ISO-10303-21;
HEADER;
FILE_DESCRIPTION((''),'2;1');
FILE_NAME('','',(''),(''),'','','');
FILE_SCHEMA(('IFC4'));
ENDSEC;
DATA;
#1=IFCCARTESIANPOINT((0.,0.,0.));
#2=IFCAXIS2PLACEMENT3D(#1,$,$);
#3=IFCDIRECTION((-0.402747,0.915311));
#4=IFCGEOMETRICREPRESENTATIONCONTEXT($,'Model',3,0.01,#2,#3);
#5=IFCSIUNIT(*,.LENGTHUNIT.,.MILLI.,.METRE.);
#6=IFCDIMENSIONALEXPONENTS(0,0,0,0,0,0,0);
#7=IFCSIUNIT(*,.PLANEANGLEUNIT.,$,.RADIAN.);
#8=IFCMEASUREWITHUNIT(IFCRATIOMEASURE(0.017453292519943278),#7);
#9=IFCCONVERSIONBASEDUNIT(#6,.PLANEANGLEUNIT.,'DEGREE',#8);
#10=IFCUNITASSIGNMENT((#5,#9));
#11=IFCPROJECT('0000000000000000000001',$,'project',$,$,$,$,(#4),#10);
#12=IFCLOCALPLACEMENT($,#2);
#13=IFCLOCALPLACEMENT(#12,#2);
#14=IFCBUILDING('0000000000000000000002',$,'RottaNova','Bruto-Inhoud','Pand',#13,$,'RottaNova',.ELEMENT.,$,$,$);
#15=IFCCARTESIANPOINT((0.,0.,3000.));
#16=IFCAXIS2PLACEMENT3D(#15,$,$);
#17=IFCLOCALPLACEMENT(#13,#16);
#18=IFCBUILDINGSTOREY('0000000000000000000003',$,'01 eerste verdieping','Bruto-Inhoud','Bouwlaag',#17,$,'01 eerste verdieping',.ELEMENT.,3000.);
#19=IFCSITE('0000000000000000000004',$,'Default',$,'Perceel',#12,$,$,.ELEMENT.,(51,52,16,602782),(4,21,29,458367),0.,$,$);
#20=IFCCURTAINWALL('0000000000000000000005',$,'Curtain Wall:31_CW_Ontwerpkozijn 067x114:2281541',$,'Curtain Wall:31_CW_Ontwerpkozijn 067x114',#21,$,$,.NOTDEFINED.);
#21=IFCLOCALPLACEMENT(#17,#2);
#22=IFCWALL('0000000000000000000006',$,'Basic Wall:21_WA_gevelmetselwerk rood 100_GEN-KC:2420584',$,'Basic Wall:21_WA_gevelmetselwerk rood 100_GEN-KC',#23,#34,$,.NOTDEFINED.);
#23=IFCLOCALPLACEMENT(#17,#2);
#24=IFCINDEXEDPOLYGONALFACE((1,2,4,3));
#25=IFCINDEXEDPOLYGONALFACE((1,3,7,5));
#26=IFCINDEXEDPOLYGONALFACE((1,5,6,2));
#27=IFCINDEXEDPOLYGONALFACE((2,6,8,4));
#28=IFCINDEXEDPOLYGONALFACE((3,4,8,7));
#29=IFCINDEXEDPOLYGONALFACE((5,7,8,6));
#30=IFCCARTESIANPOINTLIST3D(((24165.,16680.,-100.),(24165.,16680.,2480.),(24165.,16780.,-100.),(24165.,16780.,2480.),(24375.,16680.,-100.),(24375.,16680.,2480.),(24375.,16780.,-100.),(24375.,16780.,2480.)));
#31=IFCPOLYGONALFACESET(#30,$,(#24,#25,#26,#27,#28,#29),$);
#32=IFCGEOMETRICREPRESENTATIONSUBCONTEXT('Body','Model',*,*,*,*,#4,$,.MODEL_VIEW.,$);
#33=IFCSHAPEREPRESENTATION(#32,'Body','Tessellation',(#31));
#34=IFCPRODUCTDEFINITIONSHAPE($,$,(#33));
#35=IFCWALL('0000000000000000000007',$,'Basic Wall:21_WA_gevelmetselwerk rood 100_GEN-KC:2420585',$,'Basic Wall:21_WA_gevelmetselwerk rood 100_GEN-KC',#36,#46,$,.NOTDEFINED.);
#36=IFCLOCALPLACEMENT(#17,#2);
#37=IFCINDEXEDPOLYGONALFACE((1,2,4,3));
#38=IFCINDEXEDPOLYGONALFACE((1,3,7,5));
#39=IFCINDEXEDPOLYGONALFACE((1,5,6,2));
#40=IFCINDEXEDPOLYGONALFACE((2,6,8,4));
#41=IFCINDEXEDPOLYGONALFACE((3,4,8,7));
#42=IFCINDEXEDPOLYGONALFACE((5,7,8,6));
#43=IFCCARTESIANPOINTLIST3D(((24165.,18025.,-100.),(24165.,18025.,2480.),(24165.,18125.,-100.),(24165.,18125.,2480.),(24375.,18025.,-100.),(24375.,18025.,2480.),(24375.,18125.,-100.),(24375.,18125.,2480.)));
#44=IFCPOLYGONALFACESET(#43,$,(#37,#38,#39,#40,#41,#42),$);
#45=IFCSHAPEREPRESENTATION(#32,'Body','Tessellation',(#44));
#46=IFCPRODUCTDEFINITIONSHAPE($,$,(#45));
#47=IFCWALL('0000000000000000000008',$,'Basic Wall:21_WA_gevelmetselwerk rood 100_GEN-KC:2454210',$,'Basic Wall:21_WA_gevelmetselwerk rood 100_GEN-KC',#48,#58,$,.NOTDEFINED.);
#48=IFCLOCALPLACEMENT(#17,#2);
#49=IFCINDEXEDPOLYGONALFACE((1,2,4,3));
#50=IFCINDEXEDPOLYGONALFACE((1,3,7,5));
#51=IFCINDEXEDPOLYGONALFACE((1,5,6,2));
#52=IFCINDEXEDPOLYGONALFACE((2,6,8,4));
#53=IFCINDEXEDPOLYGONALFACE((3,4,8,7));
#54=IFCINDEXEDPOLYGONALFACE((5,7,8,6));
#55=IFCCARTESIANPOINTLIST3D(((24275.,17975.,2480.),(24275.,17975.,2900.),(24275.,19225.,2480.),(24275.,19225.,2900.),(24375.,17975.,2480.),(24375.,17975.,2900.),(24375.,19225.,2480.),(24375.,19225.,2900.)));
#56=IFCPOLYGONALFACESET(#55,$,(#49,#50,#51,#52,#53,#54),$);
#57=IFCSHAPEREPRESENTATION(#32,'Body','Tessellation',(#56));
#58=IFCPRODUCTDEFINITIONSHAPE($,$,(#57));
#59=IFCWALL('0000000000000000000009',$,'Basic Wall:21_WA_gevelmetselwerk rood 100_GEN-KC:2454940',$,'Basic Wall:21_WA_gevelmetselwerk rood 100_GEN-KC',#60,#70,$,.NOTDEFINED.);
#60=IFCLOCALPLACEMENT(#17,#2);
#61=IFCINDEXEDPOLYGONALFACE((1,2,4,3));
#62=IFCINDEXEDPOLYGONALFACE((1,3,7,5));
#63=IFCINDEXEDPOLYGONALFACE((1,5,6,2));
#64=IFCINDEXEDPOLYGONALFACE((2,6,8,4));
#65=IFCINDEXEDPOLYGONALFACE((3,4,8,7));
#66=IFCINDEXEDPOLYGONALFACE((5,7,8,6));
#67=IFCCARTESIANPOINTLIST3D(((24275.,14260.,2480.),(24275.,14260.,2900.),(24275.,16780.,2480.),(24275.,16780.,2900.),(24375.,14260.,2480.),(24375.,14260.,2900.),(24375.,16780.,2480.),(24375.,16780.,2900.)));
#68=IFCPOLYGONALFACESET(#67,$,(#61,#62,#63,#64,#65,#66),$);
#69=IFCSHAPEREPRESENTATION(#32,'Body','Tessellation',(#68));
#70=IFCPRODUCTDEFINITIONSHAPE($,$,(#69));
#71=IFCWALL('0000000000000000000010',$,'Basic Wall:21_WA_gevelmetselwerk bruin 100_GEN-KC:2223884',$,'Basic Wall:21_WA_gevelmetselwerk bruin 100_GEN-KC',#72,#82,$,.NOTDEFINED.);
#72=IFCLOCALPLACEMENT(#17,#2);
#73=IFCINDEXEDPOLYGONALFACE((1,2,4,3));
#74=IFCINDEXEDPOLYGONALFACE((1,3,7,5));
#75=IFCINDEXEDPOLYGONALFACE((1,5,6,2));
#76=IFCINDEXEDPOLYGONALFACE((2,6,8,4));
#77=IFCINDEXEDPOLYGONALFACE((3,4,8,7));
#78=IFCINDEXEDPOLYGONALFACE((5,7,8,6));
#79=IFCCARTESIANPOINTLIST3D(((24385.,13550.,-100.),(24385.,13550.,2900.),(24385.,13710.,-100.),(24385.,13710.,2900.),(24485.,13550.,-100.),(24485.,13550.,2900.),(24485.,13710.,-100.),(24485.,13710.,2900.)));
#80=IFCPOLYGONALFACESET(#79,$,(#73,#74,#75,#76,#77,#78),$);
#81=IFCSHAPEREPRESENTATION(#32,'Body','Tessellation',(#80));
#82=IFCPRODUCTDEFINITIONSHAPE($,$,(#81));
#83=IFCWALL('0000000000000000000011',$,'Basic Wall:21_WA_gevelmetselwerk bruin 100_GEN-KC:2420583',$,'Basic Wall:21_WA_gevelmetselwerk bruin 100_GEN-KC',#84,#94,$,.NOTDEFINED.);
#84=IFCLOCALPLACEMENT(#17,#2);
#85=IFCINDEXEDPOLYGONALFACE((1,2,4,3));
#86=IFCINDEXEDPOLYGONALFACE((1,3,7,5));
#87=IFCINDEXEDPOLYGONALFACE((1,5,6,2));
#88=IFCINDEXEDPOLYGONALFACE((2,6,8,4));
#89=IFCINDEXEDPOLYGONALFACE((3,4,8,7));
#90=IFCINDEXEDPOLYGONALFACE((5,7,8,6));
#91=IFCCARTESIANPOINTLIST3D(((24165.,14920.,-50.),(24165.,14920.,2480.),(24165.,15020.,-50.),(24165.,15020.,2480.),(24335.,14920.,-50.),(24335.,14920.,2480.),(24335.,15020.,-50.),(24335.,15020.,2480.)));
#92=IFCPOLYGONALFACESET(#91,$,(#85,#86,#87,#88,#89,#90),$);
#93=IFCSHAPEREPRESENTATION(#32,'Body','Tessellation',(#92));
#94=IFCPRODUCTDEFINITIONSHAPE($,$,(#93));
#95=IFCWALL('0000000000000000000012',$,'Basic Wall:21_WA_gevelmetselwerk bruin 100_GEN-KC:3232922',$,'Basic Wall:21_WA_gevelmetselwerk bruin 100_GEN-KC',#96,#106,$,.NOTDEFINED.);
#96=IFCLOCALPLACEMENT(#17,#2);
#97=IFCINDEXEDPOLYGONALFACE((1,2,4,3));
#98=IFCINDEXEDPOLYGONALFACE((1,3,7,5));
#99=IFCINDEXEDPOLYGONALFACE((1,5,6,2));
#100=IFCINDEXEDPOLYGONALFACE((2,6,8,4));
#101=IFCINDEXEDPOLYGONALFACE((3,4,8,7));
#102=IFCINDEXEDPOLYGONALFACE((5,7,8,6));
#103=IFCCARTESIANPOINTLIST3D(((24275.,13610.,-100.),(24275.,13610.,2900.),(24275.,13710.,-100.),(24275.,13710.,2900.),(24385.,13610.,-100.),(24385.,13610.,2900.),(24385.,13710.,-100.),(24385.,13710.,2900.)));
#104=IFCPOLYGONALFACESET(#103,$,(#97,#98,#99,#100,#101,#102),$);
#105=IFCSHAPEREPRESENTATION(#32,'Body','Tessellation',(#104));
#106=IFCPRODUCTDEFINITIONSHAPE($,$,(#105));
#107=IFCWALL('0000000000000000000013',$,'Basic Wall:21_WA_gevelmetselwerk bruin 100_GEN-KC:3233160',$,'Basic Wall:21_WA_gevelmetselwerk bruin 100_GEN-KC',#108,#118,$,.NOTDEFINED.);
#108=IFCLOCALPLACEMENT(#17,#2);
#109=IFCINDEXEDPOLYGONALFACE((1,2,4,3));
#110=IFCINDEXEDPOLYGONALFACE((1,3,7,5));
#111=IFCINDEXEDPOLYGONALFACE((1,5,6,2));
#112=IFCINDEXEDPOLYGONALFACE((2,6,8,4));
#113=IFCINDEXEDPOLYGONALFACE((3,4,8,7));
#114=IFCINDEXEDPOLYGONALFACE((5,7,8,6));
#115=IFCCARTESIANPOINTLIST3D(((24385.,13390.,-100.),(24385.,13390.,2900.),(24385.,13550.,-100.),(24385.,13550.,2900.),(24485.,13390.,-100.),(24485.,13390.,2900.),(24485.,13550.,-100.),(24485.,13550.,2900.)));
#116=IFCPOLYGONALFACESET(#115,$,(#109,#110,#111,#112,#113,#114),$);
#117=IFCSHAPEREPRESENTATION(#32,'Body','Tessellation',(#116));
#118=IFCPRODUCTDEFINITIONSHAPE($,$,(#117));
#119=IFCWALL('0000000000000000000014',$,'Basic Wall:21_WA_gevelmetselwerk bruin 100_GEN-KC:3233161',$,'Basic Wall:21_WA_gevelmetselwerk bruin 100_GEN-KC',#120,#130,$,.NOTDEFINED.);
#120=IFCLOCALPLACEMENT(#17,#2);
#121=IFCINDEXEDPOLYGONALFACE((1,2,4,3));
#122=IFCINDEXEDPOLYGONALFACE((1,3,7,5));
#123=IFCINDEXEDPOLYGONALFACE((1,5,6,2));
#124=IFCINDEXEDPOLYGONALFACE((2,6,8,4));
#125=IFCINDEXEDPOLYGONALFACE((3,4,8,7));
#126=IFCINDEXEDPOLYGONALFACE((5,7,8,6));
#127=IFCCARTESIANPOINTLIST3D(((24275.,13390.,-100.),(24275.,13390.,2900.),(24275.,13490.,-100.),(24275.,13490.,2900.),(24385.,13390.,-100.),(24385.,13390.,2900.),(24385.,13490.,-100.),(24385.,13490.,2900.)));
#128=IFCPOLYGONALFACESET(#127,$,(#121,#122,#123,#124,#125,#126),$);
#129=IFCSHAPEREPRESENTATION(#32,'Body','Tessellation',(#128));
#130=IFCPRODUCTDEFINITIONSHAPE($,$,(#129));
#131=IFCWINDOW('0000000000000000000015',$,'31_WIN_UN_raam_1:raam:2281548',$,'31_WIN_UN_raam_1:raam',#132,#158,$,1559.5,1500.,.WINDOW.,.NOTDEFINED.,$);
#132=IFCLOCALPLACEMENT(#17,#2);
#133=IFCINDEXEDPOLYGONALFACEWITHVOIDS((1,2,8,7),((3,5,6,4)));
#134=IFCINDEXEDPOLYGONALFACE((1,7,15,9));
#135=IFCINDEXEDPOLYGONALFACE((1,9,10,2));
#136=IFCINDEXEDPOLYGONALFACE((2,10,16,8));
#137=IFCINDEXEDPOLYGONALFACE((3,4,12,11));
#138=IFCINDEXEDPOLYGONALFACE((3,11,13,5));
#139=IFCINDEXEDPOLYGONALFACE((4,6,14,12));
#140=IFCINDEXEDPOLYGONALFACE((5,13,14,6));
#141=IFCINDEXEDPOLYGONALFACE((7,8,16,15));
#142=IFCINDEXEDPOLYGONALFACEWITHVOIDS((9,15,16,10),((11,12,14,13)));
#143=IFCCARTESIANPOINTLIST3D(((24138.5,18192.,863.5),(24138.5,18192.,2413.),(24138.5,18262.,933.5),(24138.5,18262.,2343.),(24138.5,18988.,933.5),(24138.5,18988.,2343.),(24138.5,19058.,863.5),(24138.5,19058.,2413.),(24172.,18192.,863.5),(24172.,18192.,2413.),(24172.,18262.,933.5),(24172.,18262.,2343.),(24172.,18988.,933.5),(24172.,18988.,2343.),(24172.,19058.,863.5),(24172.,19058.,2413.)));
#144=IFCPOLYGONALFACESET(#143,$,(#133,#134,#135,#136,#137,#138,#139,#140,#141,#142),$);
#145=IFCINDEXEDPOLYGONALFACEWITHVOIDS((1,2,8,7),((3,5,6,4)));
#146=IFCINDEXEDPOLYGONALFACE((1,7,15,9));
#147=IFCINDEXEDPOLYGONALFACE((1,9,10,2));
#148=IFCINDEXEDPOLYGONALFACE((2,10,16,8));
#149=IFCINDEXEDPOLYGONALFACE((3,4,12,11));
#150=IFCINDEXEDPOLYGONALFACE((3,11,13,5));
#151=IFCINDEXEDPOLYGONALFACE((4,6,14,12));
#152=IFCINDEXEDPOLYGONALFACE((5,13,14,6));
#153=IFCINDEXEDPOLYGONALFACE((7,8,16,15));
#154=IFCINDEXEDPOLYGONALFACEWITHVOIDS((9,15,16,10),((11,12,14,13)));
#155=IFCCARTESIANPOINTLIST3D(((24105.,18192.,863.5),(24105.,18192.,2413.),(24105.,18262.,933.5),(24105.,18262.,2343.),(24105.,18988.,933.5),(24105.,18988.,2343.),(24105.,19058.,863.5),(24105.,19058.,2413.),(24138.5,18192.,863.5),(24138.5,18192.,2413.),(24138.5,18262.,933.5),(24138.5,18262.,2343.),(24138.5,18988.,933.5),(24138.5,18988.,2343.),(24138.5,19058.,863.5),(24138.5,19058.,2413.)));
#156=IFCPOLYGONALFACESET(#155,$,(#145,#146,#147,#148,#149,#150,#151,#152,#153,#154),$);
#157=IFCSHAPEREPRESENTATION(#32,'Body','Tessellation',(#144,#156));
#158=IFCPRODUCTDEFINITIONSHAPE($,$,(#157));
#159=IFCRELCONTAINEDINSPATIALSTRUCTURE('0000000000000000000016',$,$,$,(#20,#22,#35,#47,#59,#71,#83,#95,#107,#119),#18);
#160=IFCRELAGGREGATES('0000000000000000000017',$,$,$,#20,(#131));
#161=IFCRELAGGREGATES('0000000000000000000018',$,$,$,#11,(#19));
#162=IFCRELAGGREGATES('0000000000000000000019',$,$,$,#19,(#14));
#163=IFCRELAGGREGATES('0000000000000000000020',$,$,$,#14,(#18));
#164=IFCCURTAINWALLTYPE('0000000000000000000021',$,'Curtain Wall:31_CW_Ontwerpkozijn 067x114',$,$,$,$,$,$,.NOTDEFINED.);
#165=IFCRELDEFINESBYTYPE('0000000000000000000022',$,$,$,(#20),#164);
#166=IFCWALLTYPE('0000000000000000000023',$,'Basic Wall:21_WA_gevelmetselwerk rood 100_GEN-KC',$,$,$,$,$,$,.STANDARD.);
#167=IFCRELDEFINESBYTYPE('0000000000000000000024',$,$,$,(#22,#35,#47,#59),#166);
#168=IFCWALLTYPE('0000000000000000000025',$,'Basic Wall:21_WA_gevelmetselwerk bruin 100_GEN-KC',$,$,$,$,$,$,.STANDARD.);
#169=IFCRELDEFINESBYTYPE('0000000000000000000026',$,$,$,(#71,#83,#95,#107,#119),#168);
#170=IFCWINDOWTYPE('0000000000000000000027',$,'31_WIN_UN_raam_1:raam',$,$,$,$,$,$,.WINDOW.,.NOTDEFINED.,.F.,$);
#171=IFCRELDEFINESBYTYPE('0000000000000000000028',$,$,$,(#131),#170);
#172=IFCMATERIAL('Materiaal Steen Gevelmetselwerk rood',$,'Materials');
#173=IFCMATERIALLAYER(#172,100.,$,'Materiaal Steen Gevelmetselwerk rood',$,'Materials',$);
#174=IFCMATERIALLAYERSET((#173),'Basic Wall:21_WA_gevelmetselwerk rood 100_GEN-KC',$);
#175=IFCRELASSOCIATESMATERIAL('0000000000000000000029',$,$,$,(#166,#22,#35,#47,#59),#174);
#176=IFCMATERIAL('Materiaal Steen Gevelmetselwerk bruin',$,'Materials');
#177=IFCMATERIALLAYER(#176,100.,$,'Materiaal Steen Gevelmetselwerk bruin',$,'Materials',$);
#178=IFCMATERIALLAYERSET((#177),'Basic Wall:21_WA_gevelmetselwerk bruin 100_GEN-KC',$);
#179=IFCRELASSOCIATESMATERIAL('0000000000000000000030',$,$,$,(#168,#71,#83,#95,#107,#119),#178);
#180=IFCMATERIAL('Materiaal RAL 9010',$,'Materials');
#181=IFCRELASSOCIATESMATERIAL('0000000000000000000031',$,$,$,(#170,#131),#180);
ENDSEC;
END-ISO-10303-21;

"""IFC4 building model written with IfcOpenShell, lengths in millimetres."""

from ifc_helpers import new_model, entity, si_unit, converted_unit, direction, frame, frame_2d, origin, place, context, subcontext, project, spatial, polyline, rectangle, outline, extrude, clip, bounded_halfspace, source, transform, mapped, material, layer, layer_set, type_object, type_shapes, element, aggregate, save


model = new_model("IFC4")

# Units and contexts
model_context = context("Model", 3, precision=0.01, world=origin(), true_north=direction((-0.402747, 0.915311)))
body_context = subcontext(model_context, "Body", "Model", "MODEL_VIEW")
ifc_project = project(units=[si_unit("LENGTHUNIT", "METRE", prefix="MILLI"), converted_unit("PLANEANGLEUNIT", "DEGREE", entity("IfcRatioMeasure", 0.017453292519943278), si_unit("PLANEANGLEUNIT", "RADIAN"), dimensions=[0, 0, 0, 0, 0, 0, 0])], contexts=[model_context])

# Site, building, storey
site_placement = place(None, origin())
site = spatial("IfcSite", under=ifc_project, at=site_placement, Name="Default", ObjectType="Perceel", CompositionType="ELEMENT", RefLatitude=(51, 52, 16, 602782), RefLongitude=(4, 21, 29, 458367), RefElevation=0.0)
building_placement = place(site_placement, origin())
building = spatial("IfcBuilding", under=site, at=building_placement, Name="RottaNova", Description="Bruto-Inhoud", ObjectType="Pand", LongName="RottaNova", CompositionType="ELEMENT")
storey_placement = place(building_placement, frame((0.0, 0.0, 3000.0)))
storey = spatial("IfcBuildingStorey", under=building, at=storey_placement, Name="01 eerste verdieping", Description="Bruto-Inhoud", ObjectType="Bouwlaag", LongName="01 eerste verdieping", CompositionType="ELEMENT", Elevation=3000.0)

# Curtain wall
curtain_wall_type = type_object("IfcCurtainWallType", Name="Curtain Wall:31_CW_Ontwerpkozijn 067x114", PredefinedType="NOTDEFINED")
curtain_wall_1_placement = place(storey_placement, frame((0.0, 0.0, -3000.0)))
curtain_wall_1 = element("IfcCurtainWall", 1, at=curtain_wall_1_placement, inside=storey, type_object=curtain_wall_type, Name="Curtain Wall:31_CW_Ontwerpkozijn 067x114:2281541", ObjectType="Curtain Wall:31_CW_Ontwerpkozijn 067x114", PredefinedType="NOTDEFINED")

# Shared definitions
ifc_material_1 = material(Name="Materiaal Steen Gevelmetselwerk rood", Category="Materials")
ifc_layer_1 = layer(ifc_material_1, 100.0, Name="Materiaal Steen Gevelmetselwerk rood", Category="Materials")
ifc_layer_set_1 = layer_set([ifc_layer_1], Name="Basic Wall:21_WA_gevelmetselwerk rood 100_GEN-KC")
wall_type_1 = type_object("IfcWallType", Name="Basic Wall:21_WA_gevelmetselwerk rood 100_GEN-KC", PredefinedType="STANDARD", material=ifc_layer_set_1)

# Walls
wall_1_placement = place(storey_placement, frame((24375.0, 16730.0, -100.0), z_axis=(0.0, 0.0, 1.0), x_axis=(-1.0, 0.0, 0.0)))
element("IfcWall", 2, at=wall_1_placement, inside=storey, type_object=wall_type_1, material=ifc_layer_set_1, Name="Basic Wall:21_WA_gevelmetselwerk rood 100_GEN-KC:2420584", ObjectType="Basic Wall:21_WA_gevelmetselwerk rood 100_GEN-KC", PredefinedType="NOTDEFINED", context=body_context, shape_type="SweptSolid", body=[
    extrude(rectangle(XDim=210.0, YDim=100.0, at=frame_2d((105.0, 0.0), x_axis=(-1.0, 0.0))), origin(), (0.0, 0.0, 1.0), 2580.0),
])
wall_2_placement = place(storey_placement, frame((24375.0, 18075.0, -100.0), z_axis=(0.0, 0.0, 1.0), x_axis=(-1.0, 0.0, 0.0)))
element("IfcWall", 3, at=wall_2_placement, inside=storey, type_object=wall_type_1, material=ifc_layer_set_1, Name="Basic Wall:21_WA_gevelmetselwerk rood 100_GEN-KC:2420585", ObjectType="Basic Wall:21_WA_gevelmetselwerk rood 100_GEN-KC", PredefinedType="NOTDEFINED", context=body_context, shape_type="SweptSolid", body=[
    extrude(rectangle(XDim=210.0, YDim=100.0, at=frame_2d((105.0, 0.0), x_axis=(-1.0, 0.0))), origin(), (0.0, 0.0, 1.0), 2580.0),
])
wall_3_placement = place(storey_placement, frame((24325.0, 17975.0, 2480.0), z_axis=(0.0, 0.0, 1.0), x_axis=(0.0, 1.0, 0.0)))
element("IfcWall", 4, at=wall_3_placement, inside=storey, type_object=wall_type_1, material=ifc_layer_set_1, Name="Basic Wall:21_WA_gevelmetselwerk rood 100_GEN-KC:2454210", ObjectType="Basic Wall:21_WA_gevelmetselwerk rood 100_GEN-KC", PredefinedType="NOTDEFINED", context=body_context, shape_type="SweptSolid", body=[
    extrude(rectangle(XDim=1250.0, YDim=100.0, at=frame_2d((625.0, 0.0), x_axis=(-1.0, 0.0))), origin(), (0.0, 0.0, 1.0), 420.0),
])
wall_4_placement = place(storey_placement, frame((24325.0, 14260.0, 2480.0), z_axis=(0.0, 0.0, 1.0), x_axis=(0.0, 1.0, 0.0)))
element("IfcWall", 5, at=wall_4_placement, inside=storey, type_object=wall_type_1, material=ifc_layer_set_1, Name="Basic Wall:21_WA_gevelmetselwerk rood 100_GEN-KC:2454940", ObjectType="Basic Wall:21_WA_gevelmetselwerk rood 100_GEN-KC", PredefinedType="NOTDEFINED", context=body_context, shape_type="Clipping", body=[
    clip(extrude(rectangle(XDim=2520.0, YDim=100.0, at=frame_2d((1260.0, 0.0), x_axis=(-1.0, 0.0))), origin(), (0.0, 0.0, 1.0), 420.0), bounded_halfspace(frame((2520.0, -50.0, 420.0), z_axis=(1.0, 0.0, 0.0), x_axis=(0.0, 1.0, 0.0)), False, frame((2520.0, -50.0, 420.0), z_axis=(1.0, 0.0, 0.0), x_axis=(0.0, 1.0, 0.0)), polyline([(0.0, 0.0), (0.0, -128016.0), (30480.0, -128016.0), (30480.0, 0.0), (0.0, 0.0)]))),
])
ifc_material_2 = material(Name="Materiaal Steen Gevelmetselwerk bruin", Category="Materials")
ifc_layer_2 = layer(ifc_material_2, 100.0, Name="Materiaal Steen Gevelmetselwerk bruin", Category="Materials")
ifc_layer_set_2 = layer_set([ifc_layer_2], Name="Basic Wall:21_WA_gevelmetselwerk bruin 100_GEN-KC")
wall_type_2 = type_object("IfcWallType", Name="Basic Wall:21_WA_gevelmetselwerk bruin 100_GEN-KC", PredefinedType="STANDARD", material=ifc_layer_set_2)
wall_5_placement = place(storey_placement, frame((24435.0, 13710.0, -100.0), z_axis=(0.0, 0.0, 1.0), x_axis=(0.0, -1.0, 0.0)))
element("IfcWall", 6, at=wall_5_placement, inside=storey, type_object=wall_type_2, material=ifc_layer_set_2, Name="Basic Wall:21_WA_gevelmetselwerk bruin 100_GEN-KC:2223884", ObjectType="Basic Wall:21_WA_gevelmetselwerk bruin 100_GEN-KC", PredefinedType="NOTDEFINED", context=body_context, shape_type="SweptSolid", body=[
    extrude(rectangle(XDim=160.0, YDim=100.0, at=frame_2d((80.0, 0.0), x_axis=(-1.0, 0.0))), origin(), (0.0, 0.0, 1.0), 3000.0),
])

# Walls
wall_6_placement = place(storey_placement, frame((24335.0, 14970.0, -50.0), z_axis=(0.0, 0.0, 1.0), x_axis=(-1.0, 0.0, 0.0)))
element("IfcWall", 7, at=wall_6_placement, inside=storey, type_object=wall_type_2, material=ifc_layer_set_2, Name="Basic Wall:21_WA_gevelmetselwerk bruin 100_GEN-KC:2420583", ObjectType="Basic Wall:21_WA_gevelmetselwerk bruin 100_GEN-KC", PredefinedType="NOTDEFINED", context=body_context, shape_type="SweptSolid", body=[
    extrude(rectangle(XDim=170.0, YDim=100.0, at=frame_2d((85.0, 0.0), x_axis=(-1.0, 0.0))), origin(), (0.0, 0.0, 1.0), 2530.0),
])
wall_7_placement = place(storey_placement, frame((24275.0, 13660.0, -100.0)))
element("IfcWall", 8, at=wall_7_placement, inside=storey, type_object=wall_type_2, material=ifc_layer_set_2, Name="Basic Wall:21_WA_gevelmetselwerk bruin 100_GEN-KC:3232922", ObjectType="Basic Wall:21_WA_gevelmetselwerk bruin 100_GEN-KC", PredefinedType="NOTDEFINED", context=body_context, shape_type="SweptSolid", body=[
    extrude(rectangle(XDim=110.0, YDim=100.0, at=frame_2d((55.0, 0.0), x_axis=(-1.0, 0.0))), origin(), (0.0, 0.0, 1.0), 3000.0),
])
wall_8_placement = place(storey_placement, frame((24435.0, 13390.0, -100.0), z_axis=(0.0, 0.0, 1.0), x_axis=(0.0, 1.0, 0.0)))
element("IfcWall", 9, at=wall_8_placement, inside=storey, type_object=wall_type_2, material=ifc_layer_set_2, Name="Basic Wall:21_WA_gevelmetselwerk bruin 100_GEN-KC:3233160", ObjectType="Basic Wall:21_WA_gevelmetselwerk bruin 100_GEN-KC", PredefinedType="NOTDEFINED", context=body_context, shape_type="SweptSolid", body=[
    extrude(rectangle(XDim=160.0, YDim=100.0, at=frame_2d((80.0, 0.0), x_axis=(-1.0, 0.0))), origin(), (0.0, 0.0, 1.0), 3000.0),
])
wall_9_placement = place(storey_placement, frame((24275.0, 13440.0, -100.0)))
element("IfcWall", 10, at=wall_9_placement, inside=storey, type_object=wall_type_2, material=ifc_layer_set_2, Name="Basic Wall:21_WA_gevelmetselwerk bruin 100_GEN-KC:3233161", ObjectType="Basic Wall:21_WA_gevelmetselwerk bruin 100_GEN-KC", PredefinedType="NOTDEFINED", context=body_context, shape_type="SweptSolid", body=[
    extrude(rectangle(XDim=110.0, YDim=100.0, at=frame_2d((55.0, 0.0), x_axis=(-1.0, 0.0))), origin(), (0.0, 0.0, 1.0), 3000.0),
])

# Window
ifc_material_3 = material(Name="Materiaal RAL 9010", Category="Materials")
window_type_1 = type_object("IfcWindowType", Name="31_WIN_UN_raam_1:raam", ParameterTakesPrecedence=False, PartitioningType="NOTDEFINED", PredefinedType="WINDOW", material=ifc_material_3)
shared_shape_1 = source(origin(), body_context, "Body", "SweptSolid", [
    extrude(outline(polyline([(-433.0, -774.7), (433.0, -774.7), (433.0, 774.7), (-433.0, 774.7), (-433.0, -774.7)]), holes=[polyline([(-363.0, 704.7), (363.0, 704.7), (363.0, -704.8), (-363.0, -704.8), (-363.0, 704.7)])]), frame((0.0, 92.0, 774.8), z_axis=(0.0, -1.0, 0.0), x_axis=(-1.0, 0.0, 0.0)), (0.0, 0.0, 1.0), 33.5),
    extrude(outline(polyline([(-433.0, -774.7), (433.0, -774.7), (433.0, 774.7), (-433.0, 774.7), (-433.0, -774.7)]), holes=[polyline([(-363.0, 704.7), (363.0, 704.7), (363.0, -704.8), (-363.0, -704.8), (-363.0, 704.7)])]), frame((0.0, 58.5, 774.8), z_axis=(0.0, -1.0, 0.0), x_axis=(-1.0, 0.0, 0.0)), (0.0, 0.0, 1.0), 33.5),
])
type_shapes(window_type_1, [shared_shape_1])
window_1_placement = place(curtain_wall_1_placement, frame((24080.0, 18625.0, 3863.5), z_axis=(0.0, 0.0, 1.0), x_axis=(0.0, -1.0, 0.0)))
window_1 = element("IfcWindow", 11, at=window_1_placement, type_object=window_type_1, material=ifc_material_3, Name="31_WIN_UN_raam_1:raam:2281548", ObjectType="31_WIN_UN_raam_1:raam", OverallHeight=1559.5, OverallWidth=1500.0, PartitioningType="NOTDEFINED", PredefinedType="WINDOW", context=body_context, shape_type="MappedRepresentation", body=[
    mapped(shared_shape_1, transform((0.0, 0.0, 0.0), scale=1.0)),
])
aggregate(curtain_wall_1, [window_1])

save(model, "model.ifc")
